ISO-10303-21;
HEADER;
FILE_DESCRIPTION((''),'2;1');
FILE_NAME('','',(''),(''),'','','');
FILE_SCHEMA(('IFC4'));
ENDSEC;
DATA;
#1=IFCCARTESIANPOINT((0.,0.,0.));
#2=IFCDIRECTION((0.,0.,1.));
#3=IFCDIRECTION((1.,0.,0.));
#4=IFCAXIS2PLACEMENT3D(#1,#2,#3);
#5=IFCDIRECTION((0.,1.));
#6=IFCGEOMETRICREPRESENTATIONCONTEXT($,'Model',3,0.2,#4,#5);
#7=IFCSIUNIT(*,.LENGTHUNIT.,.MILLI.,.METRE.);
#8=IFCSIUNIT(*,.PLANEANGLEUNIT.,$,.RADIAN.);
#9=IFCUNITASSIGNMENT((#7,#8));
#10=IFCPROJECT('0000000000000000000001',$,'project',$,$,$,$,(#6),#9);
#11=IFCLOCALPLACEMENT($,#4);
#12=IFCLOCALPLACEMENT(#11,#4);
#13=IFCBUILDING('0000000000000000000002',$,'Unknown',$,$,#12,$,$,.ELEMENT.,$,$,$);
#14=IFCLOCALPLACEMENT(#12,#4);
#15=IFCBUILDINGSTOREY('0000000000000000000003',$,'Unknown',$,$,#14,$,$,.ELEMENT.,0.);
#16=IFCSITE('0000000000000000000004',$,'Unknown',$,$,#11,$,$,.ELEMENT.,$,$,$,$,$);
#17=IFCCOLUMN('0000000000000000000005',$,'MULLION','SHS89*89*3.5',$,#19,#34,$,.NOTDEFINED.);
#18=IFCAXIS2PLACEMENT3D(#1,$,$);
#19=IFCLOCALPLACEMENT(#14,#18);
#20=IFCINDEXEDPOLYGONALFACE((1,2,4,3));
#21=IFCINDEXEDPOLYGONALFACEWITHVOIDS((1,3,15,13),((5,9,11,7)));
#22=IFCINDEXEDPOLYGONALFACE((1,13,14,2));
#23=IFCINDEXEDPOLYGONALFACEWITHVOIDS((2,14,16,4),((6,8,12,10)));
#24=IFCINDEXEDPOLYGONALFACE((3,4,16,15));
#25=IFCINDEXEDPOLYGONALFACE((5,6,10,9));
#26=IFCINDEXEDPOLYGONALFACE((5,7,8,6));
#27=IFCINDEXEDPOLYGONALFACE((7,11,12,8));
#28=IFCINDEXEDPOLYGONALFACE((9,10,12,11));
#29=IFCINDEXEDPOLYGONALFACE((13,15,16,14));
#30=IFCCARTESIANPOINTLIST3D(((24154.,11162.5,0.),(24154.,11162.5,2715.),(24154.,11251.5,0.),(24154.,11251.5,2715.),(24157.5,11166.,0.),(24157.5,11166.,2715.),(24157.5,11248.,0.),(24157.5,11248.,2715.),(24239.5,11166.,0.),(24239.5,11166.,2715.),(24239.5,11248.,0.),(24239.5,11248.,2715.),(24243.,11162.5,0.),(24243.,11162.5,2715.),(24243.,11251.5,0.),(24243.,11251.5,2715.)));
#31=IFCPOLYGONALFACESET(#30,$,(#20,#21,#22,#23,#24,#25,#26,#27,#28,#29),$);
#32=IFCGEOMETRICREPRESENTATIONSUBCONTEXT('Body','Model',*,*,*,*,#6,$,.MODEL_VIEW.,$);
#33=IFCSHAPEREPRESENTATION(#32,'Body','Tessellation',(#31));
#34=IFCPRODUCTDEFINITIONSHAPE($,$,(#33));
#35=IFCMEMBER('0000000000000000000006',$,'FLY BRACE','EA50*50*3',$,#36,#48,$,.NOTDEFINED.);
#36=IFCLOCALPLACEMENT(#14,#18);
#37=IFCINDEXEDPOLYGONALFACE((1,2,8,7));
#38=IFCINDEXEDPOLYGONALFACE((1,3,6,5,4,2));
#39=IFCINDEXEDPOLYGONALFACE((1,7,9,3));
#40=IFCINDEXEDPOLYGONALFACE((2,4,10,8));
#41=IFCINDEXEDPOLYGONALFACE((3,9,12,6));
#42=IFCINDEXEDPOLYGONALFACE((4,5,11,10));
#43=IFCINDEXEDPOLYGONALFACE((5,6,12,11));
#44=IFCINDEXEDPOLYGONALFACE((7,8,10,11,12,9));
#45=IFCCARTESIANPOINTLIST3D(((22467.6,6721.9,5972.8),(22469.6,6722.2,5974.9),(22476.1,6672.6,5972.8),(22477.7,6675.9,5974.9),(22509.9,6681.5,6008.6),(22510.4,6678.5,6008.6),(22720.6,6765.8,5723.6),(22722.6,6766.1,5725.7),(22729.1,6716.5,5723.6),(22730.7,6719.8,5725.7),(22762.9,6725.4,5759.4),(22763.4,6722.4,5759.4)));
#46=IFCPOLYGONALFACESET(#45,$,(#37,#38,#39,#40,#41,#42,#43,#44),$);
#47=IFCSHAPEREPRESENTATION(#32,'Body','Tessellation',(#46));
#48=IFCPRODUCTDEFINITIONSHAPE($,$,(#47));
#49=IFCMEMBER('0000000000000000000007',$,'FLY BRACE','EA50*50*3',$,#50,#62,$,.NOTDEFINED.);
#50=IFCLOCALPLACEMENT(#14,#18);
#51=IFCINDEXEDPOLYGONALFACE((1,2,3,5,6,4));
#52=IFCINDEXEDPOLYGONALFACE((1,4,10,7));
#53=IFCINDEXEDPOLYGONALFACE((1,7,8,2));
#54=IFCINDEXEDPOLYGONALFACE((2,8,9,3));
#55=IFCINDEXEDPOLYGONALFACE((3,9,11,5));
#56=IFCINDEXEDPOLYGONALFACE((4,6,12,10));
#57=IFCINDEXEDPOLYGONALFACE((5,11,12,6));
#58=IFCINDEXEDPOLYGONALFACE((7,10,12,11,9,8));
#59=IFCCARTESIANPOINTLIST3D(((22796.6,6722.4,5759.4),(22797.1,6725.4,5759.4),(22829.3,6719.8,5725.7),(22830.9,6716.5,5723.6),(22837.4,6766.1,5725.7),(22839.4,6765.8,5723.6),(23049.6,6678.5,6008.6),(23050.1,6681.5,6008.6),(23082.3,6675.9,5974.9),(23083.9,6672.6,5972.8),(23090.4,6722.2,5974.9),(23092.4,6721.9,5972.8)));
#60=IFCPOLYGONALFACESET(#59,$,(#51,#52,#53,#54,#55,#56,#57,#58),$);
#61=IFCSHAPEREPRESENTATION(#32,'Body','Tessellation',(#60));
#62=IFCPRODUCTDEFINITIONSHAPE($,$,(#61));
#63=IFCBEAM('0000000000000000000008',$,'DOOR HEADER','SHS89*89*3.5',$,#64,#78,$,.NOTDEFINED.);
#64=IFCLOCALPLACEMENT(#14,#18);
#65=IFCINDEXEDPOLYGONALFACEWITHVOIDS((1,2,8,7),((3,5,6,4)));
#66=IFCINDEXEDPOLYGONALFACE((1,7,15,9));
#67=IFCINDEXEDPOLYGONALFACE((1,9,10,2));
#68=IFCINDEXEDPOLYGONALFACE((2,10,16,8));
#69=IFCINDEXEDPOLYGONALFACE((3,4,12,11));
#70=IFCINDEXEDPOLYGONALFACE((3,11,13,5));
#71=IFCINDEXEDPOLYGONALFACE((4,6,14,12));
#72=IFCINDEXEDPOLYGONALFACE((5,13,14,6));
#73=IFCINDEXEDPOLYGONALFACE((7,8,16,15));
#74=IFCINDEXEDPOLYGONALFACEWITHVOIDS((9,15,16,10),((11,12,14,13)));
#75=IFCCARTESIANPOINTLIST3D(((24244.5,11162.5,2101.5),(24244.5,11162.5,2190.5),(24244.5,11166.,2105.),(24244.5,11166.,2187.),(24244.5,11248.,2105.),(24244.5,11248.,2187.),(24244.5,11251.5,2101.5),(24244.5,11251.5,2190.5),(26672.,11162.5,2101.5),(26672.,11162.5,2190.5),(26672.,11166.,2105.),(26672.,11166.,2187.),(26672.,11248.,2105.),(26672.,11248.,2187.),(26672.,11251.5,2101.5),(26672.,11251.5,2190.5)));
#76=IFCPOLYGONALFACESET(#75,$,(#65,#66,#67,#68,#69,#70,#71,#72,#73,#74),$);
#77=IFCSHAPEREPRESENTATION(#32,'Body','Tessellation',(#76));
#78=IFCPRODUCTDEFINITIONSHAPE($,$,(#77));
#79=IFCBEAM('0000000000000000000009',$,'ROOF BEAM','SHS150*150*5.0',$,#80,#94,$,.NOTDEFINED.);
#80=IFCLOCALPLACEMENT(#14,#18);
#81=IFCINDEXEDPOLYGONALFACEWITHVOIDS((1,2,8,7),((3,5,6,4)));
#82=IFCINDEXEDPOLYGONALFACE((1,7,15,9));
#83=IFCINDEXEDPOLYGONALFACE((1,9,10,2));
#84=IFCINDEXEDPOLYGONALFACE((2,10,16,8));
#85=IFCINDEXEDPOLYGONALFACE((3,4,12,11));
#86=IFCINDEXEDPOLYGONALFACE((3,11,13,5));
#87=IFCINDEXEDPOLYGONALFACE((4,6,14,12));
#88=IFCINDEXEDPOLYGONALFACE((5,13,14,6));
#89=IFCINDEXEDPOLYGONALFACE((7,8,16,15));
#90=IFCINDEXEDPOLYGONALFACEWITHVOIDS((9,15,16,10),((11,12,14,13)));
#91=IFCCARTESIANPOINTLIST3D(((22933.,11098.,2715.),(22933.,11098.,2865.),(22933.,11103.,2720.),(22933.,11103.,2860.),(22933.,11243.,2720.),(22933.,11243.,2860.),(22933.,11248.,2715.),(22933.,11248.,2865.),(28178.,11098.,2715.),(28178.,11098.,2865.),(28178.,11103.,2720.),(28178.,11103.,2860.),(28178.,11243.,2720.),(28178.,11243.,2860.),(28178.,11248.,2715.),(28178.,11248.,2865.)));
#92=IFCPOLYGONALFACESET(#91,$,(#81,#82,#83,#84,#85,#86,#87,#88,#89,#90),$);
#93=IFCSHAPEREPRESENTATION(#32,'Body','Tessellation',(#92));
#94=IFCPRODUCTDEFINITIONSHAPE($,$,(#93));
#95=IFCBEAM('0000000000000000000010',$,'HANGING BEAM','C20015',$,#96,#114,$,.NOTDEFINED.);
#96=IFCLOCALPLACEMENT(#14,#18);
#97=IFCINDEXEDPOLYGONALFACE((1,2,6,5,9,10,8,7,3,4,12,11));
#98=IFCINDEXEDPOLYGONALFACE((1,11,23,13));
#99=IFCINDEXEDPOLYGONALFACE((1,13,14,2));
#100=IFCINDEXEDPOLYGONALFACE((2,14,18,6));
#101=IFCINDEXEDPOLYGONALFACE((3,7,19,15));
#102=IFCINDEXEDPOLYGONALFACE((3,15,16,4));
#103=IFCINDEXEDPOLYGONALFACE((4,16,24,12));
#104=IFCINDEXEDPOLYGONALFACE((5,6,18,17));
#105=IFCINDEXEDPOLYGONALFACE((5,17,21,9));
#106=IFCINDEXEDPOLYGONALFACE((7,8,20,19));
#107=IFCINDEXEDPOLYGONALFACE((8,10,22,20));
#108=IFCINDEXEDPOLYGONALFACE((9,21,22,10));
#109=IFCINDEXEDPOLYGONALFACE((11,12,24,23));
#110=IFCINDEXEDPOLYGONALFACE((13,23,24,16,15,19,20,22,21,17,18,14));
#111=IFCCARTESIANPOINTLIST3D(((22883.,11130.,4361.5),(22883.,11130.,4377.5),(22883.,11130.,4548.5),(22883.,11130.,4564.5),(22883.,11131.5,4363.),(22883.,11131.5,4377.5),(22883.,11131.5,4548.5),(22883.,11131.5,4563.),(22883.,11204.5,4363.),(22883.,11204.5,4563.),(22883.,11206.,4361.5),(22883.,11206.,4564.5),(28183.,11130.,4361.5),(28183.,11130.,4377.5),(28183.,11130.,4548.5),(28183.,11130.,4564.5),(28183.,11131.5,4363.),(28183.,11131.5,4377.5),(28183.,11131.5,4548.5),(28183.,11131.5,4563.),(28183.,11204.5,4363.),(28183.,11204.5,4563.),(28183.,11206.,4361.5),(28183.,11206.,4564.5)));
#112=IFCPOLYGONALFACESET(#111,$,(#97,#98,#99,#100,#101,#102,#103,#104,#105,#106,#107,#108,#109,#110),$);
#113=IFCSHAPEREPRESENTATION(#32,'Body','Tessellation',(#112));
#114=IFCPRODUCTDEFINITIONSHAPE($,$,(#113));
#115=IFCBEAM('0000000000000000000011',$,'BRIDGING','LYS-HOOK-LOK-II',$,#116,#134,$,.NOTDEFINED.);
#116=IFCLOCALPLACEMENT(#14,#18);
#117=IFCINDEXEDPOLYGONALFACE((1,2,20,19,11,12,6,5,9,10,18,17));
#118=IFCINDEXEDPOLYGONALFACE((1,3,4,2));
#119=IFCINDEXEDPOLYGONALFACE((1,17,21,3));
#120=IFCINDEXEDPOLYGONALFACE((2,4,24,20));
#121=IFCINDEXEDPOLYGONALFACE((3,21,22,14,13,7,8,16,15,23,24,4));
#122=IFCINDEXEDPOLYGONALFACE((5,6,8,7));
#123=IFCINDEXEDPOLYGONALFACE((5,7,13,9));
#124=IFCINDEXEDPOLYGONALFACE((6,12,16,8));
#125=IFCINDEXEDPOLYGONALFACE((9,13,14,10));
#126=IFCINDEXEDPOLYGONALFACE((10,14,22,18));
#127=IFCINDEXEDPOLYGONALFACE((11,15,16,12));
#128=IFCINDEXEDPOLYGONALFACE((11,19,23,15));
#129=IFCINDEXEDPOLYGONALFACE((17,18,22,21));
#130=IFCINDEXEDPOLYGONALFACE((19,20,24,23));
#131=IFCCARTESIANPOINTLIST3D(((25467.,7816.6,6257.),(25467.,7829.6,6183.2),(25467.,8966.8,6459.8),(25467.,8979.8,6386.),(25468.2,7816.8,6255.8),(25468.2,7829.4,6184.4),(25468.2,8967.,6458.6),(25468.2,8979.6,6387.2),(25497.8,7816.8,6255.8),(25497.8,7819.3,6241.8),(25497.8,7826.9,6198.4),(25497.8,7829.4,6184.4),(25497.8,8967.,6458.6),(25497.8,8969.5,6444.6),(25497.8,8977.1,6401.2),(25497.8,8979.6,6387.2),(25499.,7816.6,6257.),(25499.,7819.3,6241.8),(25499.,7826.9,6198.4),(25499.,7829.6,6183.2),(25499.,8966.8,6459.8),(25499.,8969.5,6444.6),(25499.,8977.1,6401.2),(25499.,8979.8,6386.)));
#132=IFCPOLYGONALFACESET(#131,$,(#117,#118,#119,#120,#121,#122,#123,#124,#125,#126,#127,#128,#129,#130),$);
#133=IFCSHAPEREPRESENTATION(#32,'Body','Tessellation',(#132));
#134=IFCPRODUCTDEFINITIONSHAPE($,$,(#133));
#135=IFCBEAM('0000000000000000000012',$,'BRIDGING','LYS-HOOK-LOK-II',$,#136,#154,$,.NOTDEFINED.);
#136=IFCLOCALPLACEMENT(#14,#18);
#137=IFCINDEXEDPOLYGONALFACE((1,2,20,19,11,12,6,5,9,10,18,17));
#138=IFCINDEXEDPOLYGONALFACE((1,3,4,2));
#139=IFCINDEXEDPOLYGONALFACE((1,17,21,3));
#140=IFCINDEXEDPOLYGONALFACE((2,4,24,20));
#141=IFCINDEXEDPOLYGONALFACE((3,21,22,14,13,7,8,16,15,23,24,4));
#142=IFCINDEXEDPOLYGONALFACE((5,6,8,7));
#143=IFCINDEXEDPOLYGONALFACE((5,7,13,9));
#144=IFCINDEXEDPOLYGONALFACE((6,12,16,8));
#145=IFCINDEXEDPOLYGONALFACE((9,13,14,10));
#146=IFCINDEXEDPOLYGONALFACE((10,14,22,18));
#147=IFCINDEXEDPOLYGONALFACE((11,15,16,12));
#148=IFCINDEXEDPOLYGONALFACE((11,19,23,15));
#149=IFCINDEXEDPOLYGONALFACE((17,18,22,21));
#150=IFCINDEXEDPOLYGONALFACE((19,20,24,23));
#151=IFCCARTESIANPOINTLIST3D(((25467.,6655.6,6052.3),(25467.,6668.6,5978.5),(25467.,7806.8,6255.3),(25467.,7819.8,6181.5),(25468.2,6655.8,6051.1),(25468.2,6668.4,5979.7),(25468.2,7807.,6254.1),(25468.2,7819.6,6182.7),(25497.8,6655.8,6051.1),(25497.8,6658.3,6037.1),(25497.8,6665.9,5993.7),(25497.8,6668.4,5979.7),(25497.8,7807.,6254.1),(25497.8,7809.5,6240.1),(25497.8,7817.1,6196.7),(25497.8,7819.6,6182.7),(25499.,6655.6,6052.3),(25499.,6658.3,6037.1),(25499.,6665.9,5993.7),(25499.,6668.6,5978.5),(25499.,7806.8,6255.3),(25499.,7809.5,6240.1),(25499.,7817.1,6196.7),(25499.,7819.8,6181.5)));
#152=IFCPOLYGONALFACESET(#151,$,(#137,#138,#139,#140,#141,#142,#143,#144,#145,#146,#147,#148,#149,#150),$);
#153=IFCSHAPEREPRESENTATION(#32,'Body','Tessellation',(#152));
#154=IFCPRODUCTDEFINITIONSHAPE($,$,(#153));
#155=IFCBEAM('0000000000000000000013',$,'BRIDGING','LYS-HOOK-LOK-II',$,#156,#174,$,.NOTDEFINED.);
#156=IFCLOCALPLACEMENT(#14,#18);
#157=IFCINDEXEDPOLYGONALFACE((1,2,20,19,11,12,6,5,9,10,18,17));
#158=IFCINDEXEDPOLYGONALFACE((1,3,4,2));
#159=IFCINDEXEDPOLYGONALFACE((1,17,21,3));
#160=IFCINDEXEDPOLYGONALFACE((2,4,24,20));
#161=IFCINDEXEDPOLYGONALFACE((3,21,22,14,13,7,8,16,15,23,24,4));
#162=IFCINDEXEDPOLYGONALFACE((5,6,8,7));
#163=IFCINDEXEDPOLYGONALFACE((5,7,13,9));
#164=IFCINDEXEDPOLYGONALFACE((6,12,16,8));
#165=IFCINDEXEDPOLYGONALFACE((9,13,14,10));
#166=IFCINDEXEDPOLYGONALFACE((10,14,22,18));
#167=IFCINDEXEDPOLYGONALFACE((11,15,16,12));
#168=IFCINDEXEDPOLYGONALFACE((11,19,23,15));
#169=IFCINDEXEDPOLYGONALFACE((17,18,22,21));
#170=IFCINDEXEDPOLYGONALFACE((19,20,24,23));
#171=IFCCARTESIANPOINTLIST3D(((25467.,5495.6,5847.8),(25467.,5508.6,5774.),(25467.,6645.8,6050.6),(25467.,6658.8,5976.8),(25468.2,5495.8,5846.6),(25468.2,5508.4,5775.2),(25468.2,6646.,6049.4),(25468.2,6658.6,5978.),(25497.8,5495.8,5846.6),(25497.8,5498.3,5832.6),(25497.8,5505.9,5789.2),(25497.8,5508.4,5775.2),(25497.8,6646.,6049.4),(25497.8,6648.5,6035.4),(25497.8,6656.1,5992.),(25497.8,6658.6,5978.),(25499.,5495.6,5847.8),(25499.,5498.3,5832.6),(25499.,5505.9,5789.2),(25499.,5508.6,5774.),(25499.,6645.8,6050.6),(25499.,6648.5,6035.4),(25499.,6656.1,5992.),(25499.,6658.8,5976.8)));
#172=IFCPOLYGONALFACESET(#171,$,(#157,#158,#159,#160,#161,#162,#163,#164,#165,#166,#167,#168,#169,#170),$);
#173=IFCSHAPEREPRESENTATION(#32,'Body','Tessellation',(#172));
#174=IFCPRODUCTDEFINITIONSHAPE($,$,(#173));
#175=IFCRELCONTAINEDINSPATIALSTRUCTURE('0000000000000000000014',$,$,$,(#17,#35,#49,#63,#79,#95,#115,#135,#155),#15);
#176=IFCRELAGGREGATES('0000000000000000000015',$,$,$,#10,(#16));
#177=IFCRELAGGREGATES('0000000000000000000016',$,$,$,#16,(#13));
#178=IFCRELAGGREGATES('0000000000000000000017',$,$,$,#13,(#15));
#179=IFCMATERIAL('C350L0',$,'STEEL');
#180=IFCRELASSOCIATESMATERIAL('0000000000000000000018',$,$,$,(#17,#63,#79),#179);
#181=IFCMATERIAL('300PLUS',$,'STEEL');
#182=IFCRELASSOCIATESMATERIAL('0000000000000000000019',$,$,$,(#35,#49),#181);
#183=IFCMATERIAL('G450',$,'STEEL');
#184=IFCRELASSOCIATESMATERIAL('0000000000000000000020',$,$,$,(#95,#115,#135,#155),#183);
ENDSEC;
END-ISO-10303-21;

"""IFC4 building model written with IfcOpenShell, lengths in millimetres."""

from ifc_helpers import new_model, si_unit, direction, frame, origin_with_axes, place, context, subcontext, project, spatial, line, indexed_curve, outline, extrude, material, element, save


model = new_model("IFC4")

# Units and contexts
model_context = context("Model", 3, precision=0.2, world=origin_with_axes(), true_north=direction((0.0, 1.0)))
body_context = subcontext(model_context, "Body", "Model", "MODEL_VIEW")
ifc_project = project(units=[si_unit("LENGTHUNIT", "METRE", prefix="MILLI"), si_unit("PLANEANGLEUNIT", "RADIAN")], contexts=[model_context])

# Site, building, storey
site_placement = place(None, origin_with_axes())
site = spatial("IfcSite", under=ifc_project, at=site_placement, Name="Unknown", CompositionType="ELEMENT")
building_placement = place(site_placement, origin_with_axes())
building = spatial("IfcBuilding", under=site, at=building_placement, Name="Unknown", CompositionType="ELEMENT")
storey_placement = place(building_placement, origin_with_axes())
storey = spatial("IfcBuildingStorey", under=building, at=storey_placement, Name="Unknown", CompositionType="ELEMENT", Elevation=0.0)

# Column
ifc_material_1 = material(Name="C350L0", Category="STEEL")
column_placement = place(storey_placement, frame((24198.5, 11207.0, 0.0), z_axis=(-1.0, 0.0, 0.0), x_axis=(0.0, 0.0, 1.0)))
element("IfcColumn", 1, at=column_placement, inside=storey, material=ifc_material_1, Name="MULLION", Description="SHS89*89*3.5", PredefinedType="NOTDEFINED", context=body_context, shape_type="SolidModel", body=[
    extrude(outline(indexed_curve([(-44.5, -44.5), (44.5, -44.5), (44.5, 44.5), (-44.5, 44.5)], segments=[line(1, 2, 3, 4, 1)]), holes=[indexed_curve([(-41.0, -41.0), (-41.0, 41.0), (41.0, 41.0), (41.0, -41.0)], segments=[line(1, 2, 3, 4, 1)])]), frame((0.0, 0.0, 0.0), z_axis=(-1.0, 0.0, 0.0), x_axis=(0.0, 0.0, 1.0)), (0.0, 0.0, -1.0), 2715.0),
])

# Members
ifc_material_2 = material(Name="300PLUS", Category="STEEL")
for number, where, z_axis, x_axis, name in (
    (2, (22489.0, 6700.2, 5990.7), (0.686182, 0.119065, 0.71762), (0.707055, 0.122687, -0.696435), "FLY BRACE"),
    (3, (23071.0, 6700.2, 5990.7), (0.170963, 0.985277, 0.0), (-0.707055, 0.122687, -0.696435), "FLY BRACE"),
):
    element("IfcMember", number, at=place(storey_placement, frame(where, z_axis=z_axis, x_axis=x_axis)), inside=storey, material=ifc_material_2, Name=name, Description="EA50*50*3", PredefinedType="NOTDEFINED", context=body_context, shape_type="SolidModel", body=[
        extrude(outline(indexed_curve([(-25.0, -25.0), (25.0, -25.0), (25.0, -22.0), (-22.0, -22.0), (-22.0, 25.0), (-25.0, 25.0)], segments=[line(1, 2, 3, 4, 5, 6, 1)])), frame((0.0, 0.0, 0.0), z_axis=(-1.0, 0.0, 0.0), x_axis=(0.0, 0.0, 1.0)), (0.0, 0.0, -1.0), 357.8),
    ])

# Beams
beam_1_placement = place(storey_placement, frame((24244.5, 11207.0, 2146.0), z_axis=(0.0, 0.0, 1.0), x_axis=(1.0, 0.0, 0.0)))
element("IfcBeam", 4, at=beam_1_placement, inside=storey, material=ifc_material_1, Name="DOOR HEADER", Description="SHS89*89*3.5", PredefinedType="NOTDEFINED", context=body_context, shape_type="SolidModel", body=[
    extrude(outline(indexed_curve([(-44.5, -44.5), (44.5, -44.5), (44.5, 44.5), (-44.5, 44.5)], segments=[line(1, 2, 3, 4, 1)]), holes=[indexed_curve([(-41.0, -41.0), (-41.0, 41.0), (41.0, 41.0), (41.0, -41.0)], segments=[line(1, 2, 3, 4, 1)])]), frame((0.0, 0.0, 0.0), z_axis=(-1.0, 0.0, 0.0), x_axis=(0.0, 0.0, 1.0)), (0.0, 0.0, -1.0), 2427.5),
])
beam_2_placement = place(storey_placement, frame((22933.0, 11173.0, 2790.0), z_axis=(0.0, 0.0, 1.0), x_axis=(1.0, 0.0, 0.0)))
element("IfcBeam", 5, at=beam_2_placement, inside=storey, material=ifc_material_1, Name="ROOF BEAM", Description="SHS150*150*5.0", PredefinedType="NOTDEFINED", context=body_context, shape_type="SolidModel", body=[
    extrude(outline(indexed_curve([(-75.0, -75.0), (75.0, -75.0), (75.0, 75.0), (-75.0, 75.0)], segments=[line(1, 2, 3, 4, 1)]), holes=[indexed_curve([(-70.0, -70.0), (-70.0, 70.0), (70.0, 70.0), (70.0, -70.0)], segments=[line(1, 2, 3, 4, 1)])]), frame((0.0, 0.0, 0.0), z_axis=(-1.0, 0.0, 0.0), x_axis=(0.0, 0.0, 1.0)), (0.0, 0.0, -1.0), 5245.0),
])
ifc_material_3 = material(Name="G450", Category="STEEL")
beam_3_placement = place(storey_placement, frame((22883.0, 11168.0, 4463.0), z_axis=(0.0, -1.0, 0.0), x_axis=(1.0, 0.0, 0.0)))
element("IfcBeam", 6, at=beam_3_placement, inside=storey, material=ifc_material_3, Name="HANGING BEAM", Description="C20015", PredefinedType="NOTDEFINED", context=body_context, shape_type="SolidModel", body=[
    extrude(outline(indexed_curve([(38.0, -101.5), (38.0, -85.5), (36.5, -85.5), (36.5, -100.0), (-36.5, -100.0), (-36.5, 100.0), (36.5, 100.0), (36.5, 85.5), (38.0, 85.5), (38.0, 101.5), (-38.0, 101.5), (-38.0, -101.5)], segments=[line(1, 2, 3, 4, 5, 6, 7, 8, 9, 10, 11, 12, 1)])), frame((0.0, 0.0, 0.0), z_axis=(-1.0, 0.0, 0.0), x_axis=(0.0, 0.0, 1.0)), (0.0, 0.0, -1.0), 5300.0),
])
beam_4_placement = place(storey_placement, frame((25483.0, 7823.1, 6220.1), z_axis=(1.0, 0.0, 0.0), x_axis=(0.0, 0.984809, 0.173639)))
element("IfcBeam", 7, at=beam_4_placement, inside=storey, material=ifc_material_3, Name="BRIDGING", Description="LYS-HOOK-LOK-II", PredefinedType="NOTDEFINED", context=body_context, shape_type="SolidModel", body=[
    extrude(outline(indexed_curve([(16.0, -37.5), (16.0, -22.0), (14.8, -22.0), (14.8, -36.3), (-14.8, -36.3), (-14.8, 36.3), (14.8, 36.3), (14.8, 22.0), (16.0, 22.0), (16.0, 37.5), (-16.0, 37.5), (-16.0, -37.5)], segments=[line(1, 2, 3, 4, 5, 6, 7, 8, 9, 10, 11, 12, 1)])), frame((0.0, 0.0, 0.0), z_axis=(-1.0, 0.0, 0.0), x_axis=(0.0, 0.0, 1.0)), (0.0, 0.0, -1.0), 1167.9),
])
beam_5_placement = place(storey_placement, frame((25483.0, 6662.1, 6015.4), z_axis=(1.0, 0.0, 0.0), x_axis=(0.0, 0.984806, 0.173658)))
element("IfcBeam", 8, at=beam_5_placement, inside=storey, material=ifc_material_3, Name="BRIDGING", Description="LYS-HOOK-LOK-II", PredefinedType="NOTDEFINED", context=body_context, shape_type="SolidModel", body=[
    extrude(outline(indexed_curve([(16.0, -37.5), (16.0, -22.0), (14.8, -22.0), (14.8, -36.3), (-14.8, -36.3), (-14.8, 36.3), (14.8, 36.3), (14.8, 22.0), (16.0, 22.0), (16.0, 37.5), (-16.0, 37.5), (-16.0, -37.5)], segments=[line(1, 2, 3, 4, 5, 6, 7, 8, 9, 10, 11, 12, 1)])), frame((0.0, 0.0, 0.0), z_axis=(-1.0, 0.0, 0.0), x_axis=(0.0, 0.0, 1.0)), (0.0, 0.0, -1.0), 1169.0),
])
beam_6_placement = place(storey_placement, frame((25483.0, 5502.1, 5810.9), z_axis=(1.0, 0.0, 0.0), x_axis=(0.0, 0.984809, 0.173639)))
element("IfcBeam", 9, at=beam_6_placement, inside=storey, material=ifc_material_3, Name="BRIDGING", Description="LYS-HOOK-LOK-II", PredefinedType="NOTDEFINED", context=body_context, shape_type="SolidModel", body=[
    extrude(outline(indexed_curve([(16.0, -37.5), (16.0, -22.0), (14.8, -22.0), (14.8, -36.3), (-14.8, -36.3), (-14.8, 36.3), (14.8, 36.3), (14.8, 22.0), (16.0, 22.0), (16.0, 37.5), (-16.0, 37.5), (-16.0, -37.5)], segments=[line(1, 2, 3, 4, 5, 6, 7, 8, 9, 10, 11, 12, 1)])), frame((0.0, 0.0, 0.0), z_axis=(-1.0, 0.0, 0.0), x_axis=(0.0, 0.0, 1.0)), (0.0, 0.0, -1.0), 1167.9),
])

save(model, "model.ifc")
